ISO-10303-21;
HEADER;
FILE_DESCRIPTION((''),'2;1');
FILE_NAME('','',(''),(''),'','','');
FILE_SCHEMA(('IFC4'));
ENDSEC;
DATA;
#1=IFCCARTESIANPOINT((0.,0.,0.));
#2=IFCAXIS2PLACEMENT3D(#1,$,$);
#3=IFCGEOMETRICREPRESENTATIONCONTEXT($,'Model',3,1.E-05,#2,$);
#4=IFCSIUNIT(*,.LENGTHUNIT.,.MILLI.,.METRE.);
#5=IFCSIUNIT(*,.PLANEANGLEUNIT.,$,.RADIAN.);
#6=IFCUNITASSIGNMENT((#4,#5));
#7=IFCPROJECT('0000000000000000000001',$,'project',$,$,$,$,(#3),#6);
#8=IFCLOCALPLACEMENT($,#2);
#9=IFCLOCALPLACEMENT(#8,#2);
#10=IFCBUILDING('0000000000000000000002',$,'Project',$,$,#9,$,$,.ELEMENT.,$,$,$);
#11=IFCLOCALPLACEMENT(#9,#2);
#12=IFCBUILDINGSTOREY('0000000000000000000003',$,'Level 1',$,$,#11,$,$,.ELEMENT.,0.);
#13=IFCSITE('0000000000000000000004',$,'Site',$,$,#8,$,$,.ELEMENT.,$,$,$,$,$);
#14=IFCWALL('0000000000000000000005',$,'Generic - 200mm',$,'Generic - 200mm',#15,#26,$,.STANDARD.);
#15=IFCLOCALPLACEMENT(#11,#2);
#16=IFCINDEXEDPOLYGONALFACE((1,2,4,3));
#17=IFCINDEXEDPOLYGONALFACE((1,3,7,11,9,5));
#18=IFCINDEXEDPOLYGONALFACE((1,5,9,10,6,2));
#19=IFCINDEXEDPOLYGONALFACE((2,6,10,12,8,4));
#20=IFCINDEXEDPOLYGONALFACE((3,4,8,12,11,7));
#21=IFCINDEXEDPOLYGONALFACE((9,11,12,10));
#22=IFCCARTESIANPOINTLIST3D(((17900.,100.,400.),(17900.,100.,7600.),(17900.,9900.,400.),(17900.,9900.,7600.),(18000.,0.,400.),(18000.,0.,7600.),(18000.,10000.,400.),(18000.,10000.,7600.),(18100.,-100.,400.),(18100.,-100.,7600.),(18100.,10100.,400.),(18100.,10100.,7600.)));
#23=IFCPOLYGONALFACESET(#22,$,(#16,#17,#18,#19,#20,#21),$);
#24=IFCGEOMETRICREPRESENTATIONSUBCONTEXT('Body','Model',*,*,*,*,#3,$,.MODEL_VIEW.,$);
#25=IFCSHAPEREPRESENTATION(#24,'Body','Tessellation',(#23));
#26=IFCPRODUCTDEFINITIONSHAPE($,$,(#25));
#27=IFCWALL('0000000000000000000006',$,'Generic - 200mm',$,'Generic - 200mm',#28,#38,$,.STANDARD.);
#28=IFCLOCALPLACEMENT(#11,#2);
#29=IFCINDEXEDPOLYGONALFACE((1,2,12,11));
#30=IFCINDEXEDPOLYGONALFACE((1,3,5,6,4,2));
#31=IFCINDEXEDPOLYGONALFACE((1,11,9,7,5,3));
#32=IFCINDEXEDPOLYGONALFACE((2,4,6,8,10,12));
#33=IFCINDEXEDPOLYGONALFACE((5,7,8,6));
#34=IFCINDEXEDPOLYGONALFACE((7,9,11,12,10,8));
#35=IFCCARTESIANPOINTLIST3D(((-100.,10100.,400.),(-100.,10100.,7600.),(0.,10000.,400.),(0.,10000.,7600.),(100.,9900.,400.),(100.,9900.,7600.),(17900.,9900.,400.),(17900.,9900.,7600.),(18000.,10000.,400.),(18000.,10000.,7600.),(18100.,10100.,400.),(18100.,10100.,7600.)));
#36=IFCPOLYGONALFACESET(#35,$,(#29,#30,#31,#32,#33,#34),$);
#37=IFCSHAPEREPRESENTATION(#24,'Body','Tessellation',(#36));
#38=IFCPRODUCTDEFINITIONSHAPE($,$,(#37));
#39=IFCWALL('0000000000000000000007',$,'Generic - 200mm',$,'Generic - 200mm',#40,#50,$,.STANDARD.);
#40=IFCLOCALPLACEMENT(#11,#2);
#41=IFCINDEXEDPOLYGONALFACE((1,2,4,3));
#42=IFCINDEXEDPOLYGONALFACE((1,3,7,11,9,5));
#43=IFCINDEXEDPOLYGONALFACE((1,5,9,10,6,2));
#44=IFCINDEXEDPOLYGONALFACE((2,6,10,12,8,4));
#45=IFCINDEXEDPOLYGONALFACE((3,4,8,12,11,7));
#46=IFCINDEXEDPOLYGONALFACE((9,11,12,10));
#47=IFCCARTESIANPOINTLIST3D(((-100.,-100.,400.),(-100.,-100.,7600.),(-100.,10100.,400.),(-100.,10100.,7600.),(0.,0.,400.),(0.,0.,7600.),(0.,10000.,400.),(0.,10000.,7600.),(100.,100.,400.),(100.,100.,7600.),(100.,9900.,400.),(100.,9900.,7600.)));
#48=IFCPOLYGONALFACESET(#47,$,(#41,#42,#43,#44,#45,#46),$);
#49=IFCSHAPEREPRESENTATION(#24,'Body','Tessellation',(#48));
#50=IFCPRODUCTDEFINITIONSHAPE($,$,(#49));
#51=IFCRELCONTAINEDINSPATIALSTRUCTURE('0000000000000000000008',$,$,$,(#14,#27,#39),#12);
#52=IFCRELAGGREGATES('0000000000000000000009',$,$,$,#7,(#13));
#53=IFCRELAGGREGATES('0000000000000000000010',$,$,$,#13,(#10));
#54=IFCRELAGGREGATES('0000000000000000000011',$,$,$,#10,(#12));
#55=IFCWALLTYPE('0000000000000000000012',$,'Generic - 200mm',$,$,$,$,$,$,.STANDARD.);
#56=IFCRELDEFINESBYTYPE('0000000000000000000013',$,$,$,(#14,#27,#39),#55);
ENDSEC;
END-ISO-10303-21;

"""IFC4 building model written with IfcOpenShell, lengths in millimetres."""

from ifc_helpers import new_model, si_unit, frame, origin, place, context, subcontext, project, spatial, polyline, outline, extrude, type_object, element, save


model = new_model("IFC4")

# Units and contexts
model_context = context("Model", 3, precision=1e-05, world=origin())
body_context = subcontext(model_context, "Body", "Model", "MODEL_VIEW")
ifc_project = project(units=[si_unit("LENGTHUNIT", "METRE", prefix="MILLI"), si_unit("PLANEANGLEUNIT", "RADIAN")], contexts=[model_context])

# Site, building, storey
site_placement = place(None, origin())
site = spatial("IfcSite", under=ifc_project, at=site_placement, Name="Site", CompositionType="ELEMENT")
building_placement = place(site_placement, origin())
building = spatial("IfcBuilding", under=site, at=building_placement, Name="Project", CompositionType="ELEMENT")
storey_placement = place(building_placement, origin())
storey = spatial("IfcBuildingStorey", under=building, at=storey_placement, Name="Level 1", CompositionType="ELEMENT", Elevation=0.0)

# Shared definitions
wall_type = type_object("IfcWallType", Name="Generic - 200mm", PredefinedType="STANDARD")

# Walls
wall_1_placement = place(storey_placement, frame((18000.0, 0.0, 400.0), z_axis=(0.0, 0.0, 1.0), x_axis=(0.0, 1.0, 0.0)))
element("IfcWall", 1, at=wall_1_placement, inside=storey, type_object=wall_type, Name="Generic - 200mm", ObjectType="Generic - 200mm", PredefinedType="STANDARD", context=body_context, shape_type="SweptSolid", body=[
    extrude(outline(polyline([(-100.0, -100.0), (0.0, 0.0), (100.0, 100.0), (9900.0, 100.0), (10000.0, 0.0), (10100.0, -100.0), (-100.0, -100.0)])), origin(), (0.0, 0.0, 1.0), 7200.0),
])
wall_2_placement = place(storey_placement, frame((18000.0, 10000.0, 400.0), z_axis=(0.0, 0.0, 1.0), x_axis=(-1.0, 0.0, 0.0)))
element("IfcWall", 2, at=wall_2_placement, inside=storey, type_object=wall_type, Name="Generic - 200mm", ObjectType="Generic - 200mm", PredefinedType="STANDARD", context=body_context, shape_type="SweptSolid", body=[
    extrude(outline(polyline([(-100.0, -100.0), (0.0, 0.0), (100.0, 100.0), (17900.0, 100.0), (18000.0, 0.0), (18100.0, -100.0), (-100.0, -100.0)])), origin(), (0.0, 0.0, 1.0), 7200.0),
])
wall_3_placement = place(storey_placement, frame((0.0, 10000.0, 400.0), z_axis=(0.0, 0.0, 1.0), x_axis=(0.0, -1.0, 0.0)))
element("IfcWall", 3, at=wall_3_placement, inside=storey, type_object=wall_type, Name="Generic - 200mm", ObjectType="Generic - 200mm", PredefinedType="STANDARD", context=body_context, shape_type="SweptSolid", body=[
    extrude(outline(polyline([(-100.0, -100.0), (0.0, 0.0), (100.0, 100.0), (9900.0, 100.0), (10000.0, 0.0), (10100.0, -100.0), (-100.0, -100.0)])), origin(), (0.0, 0.0, 1.0), 7200.0),
])

save(model, "model.ifc")
